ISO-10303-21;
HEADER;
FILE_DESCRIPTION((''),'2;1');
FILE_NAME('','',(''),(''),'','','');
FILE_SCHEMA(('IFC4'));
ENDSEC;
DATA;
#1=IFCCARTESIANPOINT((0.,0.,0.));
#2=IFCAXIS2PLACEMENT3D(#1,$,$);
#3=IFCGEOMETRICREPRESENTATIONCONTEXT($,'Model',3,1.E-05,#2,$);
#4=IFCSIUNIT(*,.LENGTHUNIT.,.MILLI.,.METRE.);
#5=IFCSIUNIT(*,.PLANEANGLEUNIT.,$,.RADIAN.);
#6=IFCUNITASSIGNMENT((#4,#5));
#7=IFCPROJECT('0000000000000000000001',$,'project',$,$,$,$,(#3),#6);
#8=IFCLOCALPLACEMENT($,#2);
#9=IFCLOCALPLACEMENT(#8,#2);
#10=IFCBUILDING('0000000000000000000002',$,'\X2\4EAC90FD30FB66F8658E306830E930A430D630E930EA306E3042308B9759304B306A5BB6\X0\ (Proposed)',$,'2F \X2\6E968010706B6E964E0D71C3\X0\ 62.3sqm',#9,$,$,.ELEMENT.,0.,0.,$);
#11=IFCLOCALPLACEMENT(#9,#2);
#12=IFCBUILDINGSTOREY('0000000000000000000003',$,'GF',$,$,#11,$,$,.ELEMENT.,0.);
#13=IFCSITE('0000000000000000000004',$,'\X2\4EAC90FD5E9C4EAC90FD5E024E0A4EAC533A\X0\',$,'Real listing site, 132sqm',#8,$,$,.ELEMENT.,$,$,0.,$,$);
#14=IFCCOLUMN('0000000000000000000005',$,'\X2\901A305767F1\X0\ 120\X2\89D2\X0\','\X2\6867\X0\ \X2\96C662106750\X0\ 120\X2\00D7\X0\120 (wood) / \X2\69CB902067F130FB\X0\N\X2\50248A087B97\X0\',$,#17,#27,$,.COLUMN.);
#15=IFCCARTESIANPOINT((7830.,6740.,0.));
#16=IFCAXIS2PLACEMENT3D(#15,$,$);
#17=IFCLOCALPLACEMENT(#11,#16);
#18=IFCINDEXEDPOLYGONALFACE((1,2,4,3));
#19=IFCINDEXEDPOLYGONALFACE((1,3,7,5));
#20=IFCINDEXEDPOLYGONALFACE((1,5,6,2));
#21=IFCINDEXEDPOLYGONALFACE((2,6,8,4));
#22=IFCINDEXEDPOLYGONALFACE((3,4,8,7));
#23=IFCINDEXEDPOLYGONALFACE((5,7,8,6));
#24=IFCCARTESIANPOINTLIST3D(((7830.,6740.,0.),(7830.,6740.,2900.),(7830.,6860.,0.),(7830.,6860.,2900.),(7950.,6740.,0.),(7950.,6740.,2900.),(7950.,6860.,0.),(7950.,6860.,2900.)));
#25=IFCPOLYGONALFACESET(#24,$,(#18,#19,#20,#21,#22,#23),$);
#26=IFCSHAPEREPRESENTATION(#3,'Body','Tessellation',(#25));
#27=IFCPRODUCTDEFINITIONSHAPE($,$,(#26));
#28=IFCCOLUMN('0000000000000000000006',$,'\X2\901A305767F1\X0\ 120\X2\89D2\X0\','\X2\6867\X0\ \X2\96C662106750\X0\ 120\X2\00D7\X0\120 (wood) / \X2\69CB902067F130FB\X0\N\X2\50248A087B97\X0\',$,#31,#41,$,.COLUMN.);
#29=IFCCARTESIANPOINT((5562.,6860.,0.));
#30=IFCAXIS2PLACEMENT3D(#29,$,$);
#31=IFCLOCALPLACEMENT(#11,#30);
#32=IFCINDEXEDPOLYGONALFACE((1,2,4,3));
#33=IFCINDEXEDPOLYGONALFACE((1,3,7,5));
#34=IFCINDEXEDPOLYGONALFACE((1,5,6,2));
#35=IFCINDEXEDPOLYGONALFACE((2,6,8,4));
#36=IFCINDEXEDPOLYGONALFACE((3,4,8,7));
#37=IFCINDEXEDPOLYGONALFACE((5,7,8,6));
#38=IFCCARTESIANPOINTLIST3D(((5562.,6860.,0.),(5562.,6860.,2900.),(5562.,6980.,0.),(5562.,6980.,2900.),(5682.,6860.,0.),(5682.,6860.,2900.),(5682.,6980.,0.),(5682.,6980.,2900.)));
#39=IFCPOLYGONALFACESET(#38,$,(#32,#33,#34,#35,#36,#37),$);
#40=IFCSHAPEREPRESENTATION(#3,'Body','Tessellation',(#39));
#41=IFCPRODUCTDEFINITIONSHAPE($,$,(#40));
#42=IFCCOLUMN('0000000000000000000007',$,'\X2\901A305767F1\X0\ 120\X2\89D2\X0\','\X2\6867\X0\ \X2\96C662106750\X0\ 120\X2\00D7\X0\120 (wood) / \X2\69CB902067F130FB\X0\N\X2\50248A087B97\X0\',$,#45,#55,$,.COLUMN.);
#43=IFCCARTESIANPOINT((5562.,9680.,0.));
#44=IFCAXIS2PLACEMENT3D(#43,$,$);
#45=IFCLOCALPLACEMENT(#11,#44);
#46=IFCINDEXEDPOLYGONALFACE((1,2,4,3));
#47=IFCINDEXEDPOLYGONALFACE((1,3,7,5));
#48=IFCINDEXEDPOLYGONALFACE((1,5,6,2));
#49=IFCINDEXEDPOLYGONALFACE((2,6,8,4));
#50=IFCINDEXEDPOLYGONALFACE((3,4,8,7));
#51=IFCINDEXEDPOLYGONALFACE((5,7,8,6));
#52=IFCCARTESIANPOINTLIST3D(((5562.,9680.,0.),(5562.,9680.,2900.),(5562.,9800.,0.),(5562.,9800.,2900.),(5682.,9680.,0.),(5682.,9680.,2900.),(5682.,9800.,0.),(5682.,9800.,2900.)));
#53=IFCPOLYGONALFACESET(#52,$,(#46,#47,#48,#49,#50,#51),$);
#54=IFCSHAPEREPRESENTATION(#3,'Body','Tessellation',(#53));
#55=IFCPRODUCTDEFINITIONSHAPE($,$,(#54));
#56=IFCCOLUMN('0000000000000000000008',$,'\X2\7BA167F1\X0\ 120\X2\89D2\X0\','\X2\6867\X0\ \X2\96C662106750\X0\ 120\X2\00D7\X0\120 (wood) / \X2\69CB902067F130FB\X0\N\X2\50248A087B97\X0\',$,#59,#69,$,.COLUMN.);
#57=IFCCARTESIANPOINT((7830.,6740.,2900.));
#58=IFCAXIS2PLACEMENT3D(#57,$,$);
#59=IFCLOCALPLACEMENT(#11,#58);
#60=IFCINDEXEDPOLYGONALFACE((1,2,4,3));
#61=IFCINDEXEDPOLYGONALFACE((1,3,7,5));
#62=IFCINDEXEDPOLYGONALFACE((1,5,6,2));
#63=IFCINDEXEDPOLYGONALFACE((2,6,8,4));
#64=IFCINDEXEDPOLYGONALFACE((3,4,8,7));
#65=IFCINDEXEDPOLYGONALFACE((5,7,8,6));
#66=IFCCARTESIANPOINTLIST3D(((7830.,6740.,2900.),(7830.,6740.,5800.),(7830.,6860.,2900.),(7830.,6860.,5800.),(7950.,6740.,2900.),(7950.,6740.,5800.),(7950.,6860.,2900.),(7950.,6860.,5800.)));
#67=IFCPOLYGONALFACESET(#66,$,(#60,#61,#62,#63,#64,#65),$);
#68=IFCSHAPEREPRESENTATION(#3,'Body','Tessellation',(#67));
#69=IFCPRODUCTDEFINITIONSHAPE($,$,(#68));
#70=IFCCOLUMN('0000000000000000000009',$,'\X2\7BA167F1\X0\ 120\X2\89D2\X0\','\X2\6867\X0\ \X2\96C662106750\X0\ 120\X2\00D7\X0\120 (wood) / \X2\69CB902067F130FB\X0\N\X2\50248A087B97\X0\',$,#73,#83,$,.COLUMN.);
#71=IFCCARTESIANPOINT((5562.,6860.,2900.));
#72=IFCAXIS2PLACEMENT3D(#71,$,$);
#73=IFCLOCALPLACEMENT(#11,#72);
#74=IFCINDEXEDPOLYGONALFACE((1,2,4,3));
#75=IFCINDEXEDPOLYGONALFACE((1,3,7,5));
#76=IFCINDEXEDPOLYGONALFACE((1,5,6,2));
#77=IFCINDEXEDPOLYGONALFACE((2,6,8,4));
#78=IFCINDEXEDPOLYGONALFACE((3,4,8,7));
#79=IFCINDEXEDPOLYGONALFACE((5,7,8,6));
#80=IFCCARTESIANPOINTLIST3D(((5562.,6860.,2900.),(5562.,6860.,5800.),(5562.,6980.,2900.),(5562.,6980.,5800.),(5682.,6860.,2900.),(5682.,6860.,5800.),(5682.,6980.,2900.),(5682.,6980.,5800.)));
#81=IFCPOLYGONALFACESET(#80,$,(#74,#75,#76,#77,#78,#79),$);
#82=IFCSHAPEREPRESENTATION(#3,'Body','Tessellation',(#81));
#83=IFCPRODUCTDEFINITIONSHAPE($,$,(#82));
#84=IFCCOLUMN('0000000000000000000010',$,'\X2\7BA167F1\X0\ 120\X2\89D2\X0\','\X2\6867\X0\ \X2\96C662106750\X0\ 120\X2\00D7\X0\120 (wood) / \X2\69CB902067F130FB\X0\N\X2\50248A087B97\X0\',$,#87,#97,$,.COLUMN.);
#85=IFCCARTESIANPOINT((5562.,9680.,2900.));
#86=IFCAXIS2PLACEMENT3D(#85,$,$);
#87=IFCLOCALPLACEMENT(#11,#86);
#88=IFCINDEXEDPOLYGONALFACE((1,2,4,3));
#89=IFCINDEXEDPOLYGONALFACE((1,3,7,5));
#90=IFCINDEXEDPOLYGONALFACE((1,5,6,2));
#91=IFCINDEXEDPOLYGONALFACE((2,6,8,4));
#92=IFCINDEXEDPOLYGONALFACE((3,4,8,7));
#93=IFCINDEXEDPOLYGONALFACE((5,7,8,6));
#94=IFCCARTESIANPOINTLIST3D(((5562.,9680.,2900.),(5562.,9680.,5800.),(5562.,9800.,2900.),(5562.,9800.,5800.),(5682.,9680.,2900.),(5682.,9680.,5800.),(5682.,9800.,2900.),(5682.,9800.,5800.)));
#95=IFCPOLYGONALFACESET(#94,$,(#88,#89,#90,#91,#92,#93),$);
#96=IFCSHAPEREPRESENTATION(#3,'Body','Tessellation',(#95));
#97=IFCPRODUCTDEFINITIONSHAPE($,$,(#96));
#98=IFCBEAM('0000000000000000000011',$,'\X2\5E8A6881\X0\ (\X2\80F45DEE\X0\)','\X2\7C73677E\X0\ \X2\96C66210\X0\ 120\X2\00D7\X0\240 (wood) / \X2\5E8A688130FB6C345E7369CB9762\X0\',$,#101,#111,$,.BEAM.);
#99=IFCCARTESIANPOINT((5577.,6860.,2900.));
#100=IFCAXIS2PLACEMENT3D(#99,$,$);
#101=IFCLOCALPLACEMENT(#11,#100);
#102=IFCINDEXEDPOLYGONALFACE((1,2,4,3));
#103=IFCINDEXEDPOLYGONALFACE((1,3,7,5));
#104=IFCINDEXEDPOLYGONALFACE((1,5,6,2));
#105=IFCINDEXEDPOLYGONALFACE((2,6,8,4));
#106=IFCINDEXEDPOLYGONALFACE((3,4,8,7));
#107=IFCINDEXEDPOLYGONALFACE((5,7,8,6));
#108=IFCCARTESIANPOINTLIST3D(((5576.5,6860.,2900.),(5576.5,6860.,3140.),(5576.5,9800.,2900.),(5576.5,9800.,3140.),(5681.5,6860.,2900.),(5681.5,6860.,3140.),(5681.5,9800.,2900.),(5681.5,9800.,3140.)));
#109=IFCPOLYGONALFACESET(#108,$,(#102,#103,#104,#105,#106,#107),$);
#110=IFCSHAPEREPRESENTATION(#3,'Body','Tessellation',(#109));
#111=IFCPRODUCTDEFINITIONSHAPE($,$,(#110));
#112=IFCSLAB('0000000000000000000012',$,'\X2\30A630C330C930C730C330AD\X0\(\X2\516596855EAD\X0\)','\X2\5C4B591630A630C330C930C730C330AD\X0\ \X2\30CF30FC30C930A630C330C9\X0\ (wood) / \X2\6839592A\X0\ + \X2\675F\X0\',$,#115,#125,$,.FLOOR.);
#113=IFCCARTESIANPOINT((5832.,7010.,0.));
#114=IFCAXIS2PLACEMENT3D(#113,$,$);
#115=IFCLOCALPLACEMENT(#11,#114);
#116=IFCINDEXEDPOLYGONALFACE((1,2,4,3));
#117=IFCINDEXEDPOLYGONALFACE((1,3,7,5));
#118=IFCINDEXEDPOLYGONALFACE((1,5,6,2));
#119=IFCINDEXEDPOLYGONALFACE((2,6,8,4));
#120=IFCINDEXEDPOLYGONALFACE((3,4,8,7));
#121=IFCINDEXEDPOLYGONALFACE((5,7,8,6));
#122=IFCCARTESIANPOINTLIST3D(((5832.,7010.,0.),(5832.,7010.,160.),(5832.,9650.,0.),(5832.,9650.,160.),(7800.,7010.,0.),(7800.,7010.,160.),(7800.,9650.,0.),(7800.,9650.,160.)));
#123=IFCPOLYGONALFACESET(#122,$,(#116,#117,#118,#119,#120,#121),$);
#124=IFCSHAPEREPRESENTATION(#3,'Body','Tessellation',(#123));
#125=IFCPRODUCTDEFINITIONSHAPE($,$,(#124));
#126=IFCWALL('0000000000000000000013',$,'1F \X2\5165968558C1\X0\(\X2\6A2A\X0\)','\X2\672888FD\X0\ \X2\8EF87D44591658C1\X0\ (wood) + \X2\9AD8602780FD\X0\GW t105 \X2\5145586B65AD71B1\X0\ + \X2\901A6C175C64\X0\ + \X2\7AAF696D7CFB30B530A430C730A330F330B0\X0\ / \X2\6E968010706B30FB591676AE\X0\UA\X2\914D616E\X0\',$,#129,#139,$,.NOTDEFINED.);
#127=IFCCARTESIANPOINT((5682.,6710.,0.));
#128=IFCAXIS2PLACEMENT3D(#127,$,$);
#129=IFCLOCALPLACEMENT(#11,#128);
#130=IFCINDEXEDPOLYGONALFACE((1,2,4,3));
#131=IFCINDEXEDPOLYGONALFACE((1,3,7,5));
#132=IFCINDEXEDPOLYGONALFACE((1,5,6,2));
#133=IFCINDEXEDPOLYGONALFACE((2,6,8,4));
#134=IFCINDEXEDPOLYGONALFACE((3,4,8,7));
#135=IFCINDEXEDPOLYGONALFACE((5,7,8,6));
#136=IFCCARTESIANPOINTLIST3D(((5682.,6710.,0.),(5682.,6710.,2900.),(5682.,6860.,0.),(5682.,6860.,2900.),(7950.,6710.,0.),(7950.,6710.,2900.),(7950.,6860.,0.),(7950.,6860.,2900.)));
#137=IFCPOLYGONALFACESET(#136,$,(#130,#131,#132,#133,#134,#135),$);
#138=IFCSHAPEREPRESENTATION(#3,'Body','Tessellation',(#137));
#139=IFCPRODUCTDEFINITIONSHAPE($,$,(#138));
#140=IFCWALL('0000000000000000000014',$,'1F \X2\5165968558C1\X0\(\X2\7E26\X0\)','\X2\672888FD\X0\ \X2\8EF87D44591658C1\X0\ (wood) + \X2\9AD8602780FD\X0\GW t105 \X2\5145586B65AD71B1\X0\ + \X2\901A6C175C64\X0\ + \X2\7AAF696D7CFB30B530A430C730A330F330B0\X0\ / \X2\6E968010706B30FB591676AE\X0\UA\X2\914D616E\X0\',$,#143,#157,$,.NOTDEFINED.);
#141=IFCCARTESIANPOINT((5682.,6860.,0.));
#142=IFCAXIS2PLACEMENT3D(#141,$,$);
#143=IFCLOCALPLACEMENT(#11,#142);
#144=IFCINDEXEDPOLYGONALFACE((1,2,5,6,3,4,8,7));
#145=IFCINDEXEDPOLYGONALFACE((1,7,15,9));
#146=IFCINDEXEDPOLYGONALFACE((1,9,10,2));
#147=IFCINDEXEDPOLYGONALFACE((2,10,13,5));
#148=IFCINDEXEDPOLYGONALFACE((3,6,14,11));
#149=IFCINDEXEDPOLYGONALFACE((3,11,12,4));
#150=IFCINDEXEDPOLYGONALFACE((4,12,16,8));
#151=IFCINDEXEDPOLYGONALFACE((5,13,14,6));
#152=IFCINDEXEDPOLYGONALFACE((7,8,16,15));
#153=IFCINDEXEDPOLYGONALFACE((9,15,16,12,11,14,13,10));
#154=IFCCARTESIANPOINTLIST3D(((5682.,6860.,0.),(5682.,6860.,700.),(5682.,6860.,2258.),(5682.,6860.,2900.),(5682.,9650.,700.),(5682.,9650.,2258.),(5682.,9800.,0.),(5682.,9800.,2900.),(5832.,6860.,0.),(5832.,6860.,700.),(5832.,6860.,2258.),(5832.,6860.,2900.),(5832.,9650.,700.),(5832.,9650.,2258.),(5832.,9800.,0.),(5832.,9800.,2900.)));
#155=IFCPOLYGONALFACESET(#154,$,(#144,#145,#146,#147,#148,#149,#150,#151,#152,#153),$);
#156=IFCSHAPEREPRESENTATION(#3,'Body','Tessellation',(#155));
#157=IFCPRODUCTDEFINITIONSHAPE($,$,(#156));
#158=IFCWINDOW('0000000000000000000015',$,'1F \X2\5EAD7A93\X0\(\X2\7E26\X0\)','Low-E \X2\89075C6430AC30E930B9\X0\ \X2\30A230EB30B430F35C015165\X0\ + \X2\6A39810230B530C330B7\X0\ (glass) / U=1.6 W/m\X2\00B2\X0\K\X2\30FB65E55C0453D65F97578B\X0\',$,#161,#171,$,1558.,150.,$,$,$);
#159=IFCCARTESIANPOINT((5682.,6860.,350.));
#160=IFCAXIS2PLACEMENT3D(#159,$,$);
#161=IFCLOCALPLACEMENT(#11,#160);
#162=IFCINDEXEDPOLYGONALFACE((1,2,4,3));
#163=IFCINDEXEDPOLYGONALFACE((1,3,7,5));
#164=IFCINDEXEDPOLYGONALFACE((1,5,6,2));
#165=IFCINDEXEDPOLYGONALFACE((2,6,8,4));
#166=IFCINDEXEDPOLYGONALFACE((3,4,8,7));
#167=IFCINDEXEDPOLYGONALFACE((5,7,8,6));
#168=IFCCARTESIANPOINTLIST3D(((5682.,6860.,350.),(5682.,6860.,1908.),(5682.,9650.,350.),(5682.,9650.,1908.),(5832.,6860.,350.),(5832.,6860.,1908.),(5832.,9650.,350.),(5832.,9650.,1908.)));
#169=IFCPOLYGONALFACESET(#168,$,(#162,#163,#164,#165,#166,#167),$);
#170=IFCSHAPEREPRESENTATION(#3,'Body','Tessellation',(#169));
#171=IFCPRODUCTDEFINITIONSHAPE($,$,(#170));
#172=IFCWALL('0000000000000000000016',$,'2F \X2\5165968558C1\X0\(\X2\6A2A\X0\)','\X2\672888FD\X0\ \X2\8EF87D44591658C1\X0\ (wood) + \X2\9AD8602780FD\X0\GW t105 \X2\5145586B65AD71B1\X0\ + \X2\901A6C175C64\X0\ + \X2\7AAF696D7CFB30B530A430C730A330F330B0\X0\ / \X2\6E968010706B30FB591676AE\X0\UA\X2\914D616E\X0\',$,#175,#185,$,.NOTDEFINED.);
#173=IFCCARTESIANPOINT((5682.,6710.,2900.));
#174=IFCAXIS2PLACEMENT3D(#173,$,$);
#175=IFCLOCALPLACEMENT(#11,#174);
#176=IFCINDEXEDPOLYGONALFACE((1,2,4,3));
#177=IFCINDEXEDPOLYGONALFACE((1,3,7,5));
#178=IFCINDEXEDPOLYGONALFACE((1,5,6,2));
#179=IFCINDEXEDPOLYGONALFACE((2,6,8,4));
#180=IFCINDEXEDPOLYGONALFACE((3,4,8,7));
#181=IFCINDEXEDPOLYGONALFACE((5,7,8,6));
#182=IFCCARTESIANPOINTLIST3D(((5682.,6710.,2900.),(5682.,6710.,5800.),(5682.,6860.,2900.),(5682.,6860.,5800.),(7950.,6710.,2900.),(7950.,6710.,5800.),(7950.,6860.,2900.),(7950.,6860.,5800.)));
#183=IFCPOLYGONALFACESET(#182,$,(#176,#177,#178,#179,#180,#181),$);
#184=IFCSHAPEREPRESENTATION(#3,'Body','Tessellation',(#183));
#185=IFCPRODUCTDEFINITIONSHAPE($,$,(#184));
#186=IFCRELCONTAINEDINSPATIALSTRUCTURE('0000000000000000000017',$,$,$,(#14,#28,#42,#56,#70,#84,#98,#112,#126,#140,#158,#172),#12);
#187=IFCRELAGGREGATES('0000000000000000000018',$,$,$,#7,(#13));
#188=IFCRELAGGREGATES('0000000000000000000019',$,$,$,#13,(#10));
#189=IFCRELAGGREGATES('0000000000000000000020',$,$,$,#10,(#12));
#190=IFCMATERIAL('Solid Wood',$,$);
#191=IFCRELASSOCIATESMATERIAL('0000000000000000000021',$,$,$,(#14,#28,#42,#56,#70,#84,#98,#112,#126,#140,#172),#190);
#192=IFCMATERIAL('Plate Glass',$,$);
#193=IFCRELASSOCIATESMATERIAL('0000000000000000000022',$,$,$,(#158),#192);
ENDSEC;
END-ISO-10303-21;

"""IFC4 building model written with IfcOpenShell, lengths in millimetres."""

from ifc_helpers import new_model, si_unit, frame, frame_2d, origin, place, context, project, spatial, rectangle, extrude, material, element, fill, save


model = new_model("IFC4")

# Units and contexts
model_context = context("Model", 3, precision=1e-05, world=origin())
ifc_project = project(units=[si_unit("LENGTHUNIT", "METRE", prefix="MILLI"), si_unit("PLANEANGLEUNIT", "RADIAN")], contexts=[model_context])

# Site, building, storey
site_placement = place(None, origin())
site = spatial("IfcSite", under=ifc_project, at=site_placement, Name="京都府京都市上京区", ObjectType="Real listing site, 132sqm", CompositionType="ELEMENT", RefElevation=0.0)
building_placement = place(site_placement, origin())
building = spatial("IfcBuilding", under=site, at=building_placement, Name="京都・書斎とライブラリのある静かな家 (Proposed)", ObjectType="2F 準耐火準不燃 62.3sqm", CompositionType="ELEMENT", ElevationOfRefHeight=0.0, ElevationOfTerrain=0.0)
storey_placement = place(building_placement, origin())
storey = spatial("IfcBuildingStorey", under=building, at=storey_placement, Name="GF", CompositionType="ELEMENT", Elevation=0.0)

# Columns
ifc_material_1 = material(Name="Solid Wood")
column_1_placement = place(storey_placement, frame((7830.0, 6740.0, 0.0)))
element("IfcColumn", 1, at=column_1_placement, inside=storey, material=ifc_material_1, Name="通し柱 120角", Description="桧 集成材 120×120 (wood) / 構造柱・N値計算", PredefinedType="COLUMN", context=model_context, shape_type="SweptSolid", body=[
    extrude(rectangle(XDim=120.0, YDim=120.0, at=frame_2d((60.0, 60.0))), frame((7830.0, 6740.0, 0.0)), (0.0, 0.0, 1.0), 2900.0),
])
column_2_placement = place(storey_placement, frame((5562.0, 6860.0, 0.0)))
element("IfcColumn", 2, at=column_2_placement, inside=storey, material=ifc_material_1, Name="通し柱 120角", Description="桧 集成材 120×120 (wood) / 構造柱・N値計算", PredefinedType="COLUMN", context=model_context, shape_type="SweptSolid", body=[
    extrude(rectangle(XDim=120.0, YDim=120.0, at=frame_2d((60.0, 60.0))), frame((5562.0, 6860.0, 0.0)), (0.0, 0.0, 1.0), 2900.0),
])
column_3_placement = place(storey_placement, frame((5562.0, 9680.0, 0.0)))
element("IfcColumn", 3, at=column_3_placement, inside=storey, material=ifc_material_1, Name="通し柱 120角", Description="桧 集成材 120×120 (wood) / 構造柱・N値計算", PredefinedType="COLUMN", context=model_context, shape_type="SweptSolid", body=[
    extrude(rectangle(XDim=120.0, YDim=120.0, at=frame_2d((60.0, 60.0))), frame((5562.0, 9680.0, 0.0)), (0.0, 0.0, 1.0), 2900.0),
])
column_4_placement = place(storey_placement, frame((7830.0, 6740.0, 2900.0)))
element("IfcColumn", 4, at=column_4_placement, inside=storey, material=ifc_material_1, Name="管柱 120角", Description="桧 集成材 120×120 (wood) / 構造柱・N値計算", PredefinedType="COLUMN", context=model_context, shape_type="SweptSolid", body=[
    extrude(rectangle(XDim=120.0, YDim=120.0, at=frame_2d((60.0, 60.0))), frame((7830.0, 6740.0, 2900.0)), (0.0, 0.0, 1.0), 2900.0),
])
column_5_placement = place(storey_placement, frame((5562.0, 6860.0, 2900.0)))
element("IfcColumn", 5, at=column_5_placement, inside=storey, material=ifc_material_1, Name="管柱 120角", Description="桧 集成材 120×120 (wood) / 構造柱・N値計算", PredefinedType="COLUMN", context=model_context, shape_type="SweptSolid", body=[
    extrude(rectangle(XDim=120.0, YDim=120.0, at=frame_2d((60.0, 60.0))), frame((5562.0, 6860.0, 2900.0)), (0.0, 0.0, 1.0), 2900.0),
])
column_6_placement = place(storey_placement, frame((5562.0, 9680.0, 2900.0)))
element("IfcColumn", 6, at=column_6_placement, inside=storey, material=ifc_material_1, Name="管柱 120角", Description="桧 集成材 120×120 (wood) / 構造柱・N値計算", PredefinedType="COLUMN", context=model_context, shape_type="SweptSolid", body=[
    extrude(rectangle(XDim=120.0, YDim=120.0, at=frame_2d((60.0, 60.0))), frame((5562.0, 9680.0, 2900.0)), (0.0, 0.0, 1.0), 2900.0),
])

# Beam
beam_1_placement = place(storey_placement, frame((5577.0, 6860.0, 2900.0)))
element("IfcBeam", 7, at=beam_1_placement, inside=storey, material=ifc_material_1, Name="床梁 (胴差)", Description="米松 集成 120×240 (wood) / 床梁・水平構面", PredefinedType="BEAM", context=model_context, shape_type="SweptSolid", body=[
    extrude(rectangle(XDim=105.0, YDim=2940.0, at=frame_2d((52.0, 1470.0))), frame((5577.0, 6860.0, 2900.0)), (0.0, 0.0, 1.0), 240.0),
])

# Slab
slab_placement = place(storey_placement, frame((5832.0, 7010.0, 0.0)))
element("IfcSlab", 8, at=slab_placement, inside=storey, material=ifc_material_1, Name="ウッドデッキ(入隅庭)", Description="屋外ウッドデッキ ハードウッド (wood) / 根太 + 束", PredefinedType="FLOOR", context=model_context, shape_type="SweptSolid", body=[
    extrude(rectangle(XDim=1968.0, YDim=2640.0, at=frame_2d((984.0, 1320.0))), frame((5832.0, 7010.0, 0.0)), (0.0, 0.0, 1.0), 160.0),
])

# Wall
wall_1_placement = place(storey_placement, frame((5682.0, 6710.0, 0.0)))
element("IfcWall", 9, at=wall_1_placement, inside=storey, material=ifc_material_1, Name="1F 入隅壁(横)", Description="木製 軸組外壁 (wood) + 高性能GW t105 充填断熱 + 通気層 + 窯業系サイディング / 準耐火・外皮UA配慮", PredefinedType="NOTDEFINED", context=model_context, shape_type="SweptSolid", body=[
    extrude(rectangle(XDim=2268.0, YDim=150.0, at=frame_2d((1134.0, 75.0))), frame((5682.0, 6710.0, 0.0)), (0.0, 0.0, 1.0), 2900.0),
])

# Wall, opening, window
wall_2_placement = place(storey_placement, frame((5682.0, 6860.0, 0.0)))
wall_2 = element("IfcWall", 10, at=wall_2_placement, inside=storey, material=ifc_material_1, Name="1F 入隅壁(縦)", Description="木製 軸組外壁 (wood) + 高性能GW t105 充填断熱 + 通気層 + 窯業系サイディング / 準耐火・外皮UA配慮", PredefinedType="NOTDEFINED", context=model_context, shape_type="SweptSolid", body=[
    extrude(rectangle(XDim=150.0, YDim=2940.0, at=frame_2d((75.0, 1470.0))), frame((5682.0, 6860.0, 0.0)), (0.0, 0.0, 1.0), 2900.0),
])
opening_1_placement = place(storey_placement, frame((5682.0, 6860.0, 350.0)))
opening_1 = element("IfcOpeningElement", 11, at=opening_1_placement, cuts=wall_2, PredefinedType="NOTDEFINED", context=model_context, shape_type="SweptSolid", body=[
    extrude(rectangle(XDim=150.0, YDim=2790.0, at=frame_2d((75.0, 1395.0))), frame((5682.0, 6860.0, 350.0)), (0.0, 0.0, 1.0), 1558.0),
])
ifc_material_2 = material(Name="Plate Glass")
window_1_placement = place(storey_placement, frame((5682.0, 6860.0, 350.0)))
window_1 = element("IfcWindow", 12, at=window_1_placement, inside=storey, material=ifc_material_2, Name="1F 庭窓(縦)", Description="Low-E 複層ガラス アルゴン封入 + 樹脂サッシ (glass) / U=1.6 W/m²K・日射取得型", OverallHeight=1558.0, OverallWidth=150.0, context=model_context, shape_type="SweptSolid", body=[
    extrude(rectangle(XDim=150.0, YDim=2790.0, at=frame_2d((75.0, 1395.0))), frame((5682.0, 6860.0, 350.0)), (0.0, 0.0, 1.0), 1558.0),
])
fill(opening_1, window_1)

# Wall
wall_3_placement = place(storey_placement, frame((5682.0, 6710.0, 2900.0)))
element("IfcWall", 13, at=wall_3_placement, inside=storey, material=ifc_material_1, Name="2F 入隅壁(横)", Description="木製 軸組外壁 (wood) + 高性能GW t105 充填断熱 + 通気層 + 窯業系サイディング / 準耐火・外皮UA配慮", PredefinedType="NOTDEFINED", context=model_context, shape_type="SweptSolid", body=[
    extrude(rectangle(XDim=2268.0, YDim=150.0, at=frame_2d((1134.0, 75.0))), frame((5682.0, 6710.0, 2900.0)), (0.0, 0.0, 1.0), 2900.0),
])

save(model, "model.ifc")
